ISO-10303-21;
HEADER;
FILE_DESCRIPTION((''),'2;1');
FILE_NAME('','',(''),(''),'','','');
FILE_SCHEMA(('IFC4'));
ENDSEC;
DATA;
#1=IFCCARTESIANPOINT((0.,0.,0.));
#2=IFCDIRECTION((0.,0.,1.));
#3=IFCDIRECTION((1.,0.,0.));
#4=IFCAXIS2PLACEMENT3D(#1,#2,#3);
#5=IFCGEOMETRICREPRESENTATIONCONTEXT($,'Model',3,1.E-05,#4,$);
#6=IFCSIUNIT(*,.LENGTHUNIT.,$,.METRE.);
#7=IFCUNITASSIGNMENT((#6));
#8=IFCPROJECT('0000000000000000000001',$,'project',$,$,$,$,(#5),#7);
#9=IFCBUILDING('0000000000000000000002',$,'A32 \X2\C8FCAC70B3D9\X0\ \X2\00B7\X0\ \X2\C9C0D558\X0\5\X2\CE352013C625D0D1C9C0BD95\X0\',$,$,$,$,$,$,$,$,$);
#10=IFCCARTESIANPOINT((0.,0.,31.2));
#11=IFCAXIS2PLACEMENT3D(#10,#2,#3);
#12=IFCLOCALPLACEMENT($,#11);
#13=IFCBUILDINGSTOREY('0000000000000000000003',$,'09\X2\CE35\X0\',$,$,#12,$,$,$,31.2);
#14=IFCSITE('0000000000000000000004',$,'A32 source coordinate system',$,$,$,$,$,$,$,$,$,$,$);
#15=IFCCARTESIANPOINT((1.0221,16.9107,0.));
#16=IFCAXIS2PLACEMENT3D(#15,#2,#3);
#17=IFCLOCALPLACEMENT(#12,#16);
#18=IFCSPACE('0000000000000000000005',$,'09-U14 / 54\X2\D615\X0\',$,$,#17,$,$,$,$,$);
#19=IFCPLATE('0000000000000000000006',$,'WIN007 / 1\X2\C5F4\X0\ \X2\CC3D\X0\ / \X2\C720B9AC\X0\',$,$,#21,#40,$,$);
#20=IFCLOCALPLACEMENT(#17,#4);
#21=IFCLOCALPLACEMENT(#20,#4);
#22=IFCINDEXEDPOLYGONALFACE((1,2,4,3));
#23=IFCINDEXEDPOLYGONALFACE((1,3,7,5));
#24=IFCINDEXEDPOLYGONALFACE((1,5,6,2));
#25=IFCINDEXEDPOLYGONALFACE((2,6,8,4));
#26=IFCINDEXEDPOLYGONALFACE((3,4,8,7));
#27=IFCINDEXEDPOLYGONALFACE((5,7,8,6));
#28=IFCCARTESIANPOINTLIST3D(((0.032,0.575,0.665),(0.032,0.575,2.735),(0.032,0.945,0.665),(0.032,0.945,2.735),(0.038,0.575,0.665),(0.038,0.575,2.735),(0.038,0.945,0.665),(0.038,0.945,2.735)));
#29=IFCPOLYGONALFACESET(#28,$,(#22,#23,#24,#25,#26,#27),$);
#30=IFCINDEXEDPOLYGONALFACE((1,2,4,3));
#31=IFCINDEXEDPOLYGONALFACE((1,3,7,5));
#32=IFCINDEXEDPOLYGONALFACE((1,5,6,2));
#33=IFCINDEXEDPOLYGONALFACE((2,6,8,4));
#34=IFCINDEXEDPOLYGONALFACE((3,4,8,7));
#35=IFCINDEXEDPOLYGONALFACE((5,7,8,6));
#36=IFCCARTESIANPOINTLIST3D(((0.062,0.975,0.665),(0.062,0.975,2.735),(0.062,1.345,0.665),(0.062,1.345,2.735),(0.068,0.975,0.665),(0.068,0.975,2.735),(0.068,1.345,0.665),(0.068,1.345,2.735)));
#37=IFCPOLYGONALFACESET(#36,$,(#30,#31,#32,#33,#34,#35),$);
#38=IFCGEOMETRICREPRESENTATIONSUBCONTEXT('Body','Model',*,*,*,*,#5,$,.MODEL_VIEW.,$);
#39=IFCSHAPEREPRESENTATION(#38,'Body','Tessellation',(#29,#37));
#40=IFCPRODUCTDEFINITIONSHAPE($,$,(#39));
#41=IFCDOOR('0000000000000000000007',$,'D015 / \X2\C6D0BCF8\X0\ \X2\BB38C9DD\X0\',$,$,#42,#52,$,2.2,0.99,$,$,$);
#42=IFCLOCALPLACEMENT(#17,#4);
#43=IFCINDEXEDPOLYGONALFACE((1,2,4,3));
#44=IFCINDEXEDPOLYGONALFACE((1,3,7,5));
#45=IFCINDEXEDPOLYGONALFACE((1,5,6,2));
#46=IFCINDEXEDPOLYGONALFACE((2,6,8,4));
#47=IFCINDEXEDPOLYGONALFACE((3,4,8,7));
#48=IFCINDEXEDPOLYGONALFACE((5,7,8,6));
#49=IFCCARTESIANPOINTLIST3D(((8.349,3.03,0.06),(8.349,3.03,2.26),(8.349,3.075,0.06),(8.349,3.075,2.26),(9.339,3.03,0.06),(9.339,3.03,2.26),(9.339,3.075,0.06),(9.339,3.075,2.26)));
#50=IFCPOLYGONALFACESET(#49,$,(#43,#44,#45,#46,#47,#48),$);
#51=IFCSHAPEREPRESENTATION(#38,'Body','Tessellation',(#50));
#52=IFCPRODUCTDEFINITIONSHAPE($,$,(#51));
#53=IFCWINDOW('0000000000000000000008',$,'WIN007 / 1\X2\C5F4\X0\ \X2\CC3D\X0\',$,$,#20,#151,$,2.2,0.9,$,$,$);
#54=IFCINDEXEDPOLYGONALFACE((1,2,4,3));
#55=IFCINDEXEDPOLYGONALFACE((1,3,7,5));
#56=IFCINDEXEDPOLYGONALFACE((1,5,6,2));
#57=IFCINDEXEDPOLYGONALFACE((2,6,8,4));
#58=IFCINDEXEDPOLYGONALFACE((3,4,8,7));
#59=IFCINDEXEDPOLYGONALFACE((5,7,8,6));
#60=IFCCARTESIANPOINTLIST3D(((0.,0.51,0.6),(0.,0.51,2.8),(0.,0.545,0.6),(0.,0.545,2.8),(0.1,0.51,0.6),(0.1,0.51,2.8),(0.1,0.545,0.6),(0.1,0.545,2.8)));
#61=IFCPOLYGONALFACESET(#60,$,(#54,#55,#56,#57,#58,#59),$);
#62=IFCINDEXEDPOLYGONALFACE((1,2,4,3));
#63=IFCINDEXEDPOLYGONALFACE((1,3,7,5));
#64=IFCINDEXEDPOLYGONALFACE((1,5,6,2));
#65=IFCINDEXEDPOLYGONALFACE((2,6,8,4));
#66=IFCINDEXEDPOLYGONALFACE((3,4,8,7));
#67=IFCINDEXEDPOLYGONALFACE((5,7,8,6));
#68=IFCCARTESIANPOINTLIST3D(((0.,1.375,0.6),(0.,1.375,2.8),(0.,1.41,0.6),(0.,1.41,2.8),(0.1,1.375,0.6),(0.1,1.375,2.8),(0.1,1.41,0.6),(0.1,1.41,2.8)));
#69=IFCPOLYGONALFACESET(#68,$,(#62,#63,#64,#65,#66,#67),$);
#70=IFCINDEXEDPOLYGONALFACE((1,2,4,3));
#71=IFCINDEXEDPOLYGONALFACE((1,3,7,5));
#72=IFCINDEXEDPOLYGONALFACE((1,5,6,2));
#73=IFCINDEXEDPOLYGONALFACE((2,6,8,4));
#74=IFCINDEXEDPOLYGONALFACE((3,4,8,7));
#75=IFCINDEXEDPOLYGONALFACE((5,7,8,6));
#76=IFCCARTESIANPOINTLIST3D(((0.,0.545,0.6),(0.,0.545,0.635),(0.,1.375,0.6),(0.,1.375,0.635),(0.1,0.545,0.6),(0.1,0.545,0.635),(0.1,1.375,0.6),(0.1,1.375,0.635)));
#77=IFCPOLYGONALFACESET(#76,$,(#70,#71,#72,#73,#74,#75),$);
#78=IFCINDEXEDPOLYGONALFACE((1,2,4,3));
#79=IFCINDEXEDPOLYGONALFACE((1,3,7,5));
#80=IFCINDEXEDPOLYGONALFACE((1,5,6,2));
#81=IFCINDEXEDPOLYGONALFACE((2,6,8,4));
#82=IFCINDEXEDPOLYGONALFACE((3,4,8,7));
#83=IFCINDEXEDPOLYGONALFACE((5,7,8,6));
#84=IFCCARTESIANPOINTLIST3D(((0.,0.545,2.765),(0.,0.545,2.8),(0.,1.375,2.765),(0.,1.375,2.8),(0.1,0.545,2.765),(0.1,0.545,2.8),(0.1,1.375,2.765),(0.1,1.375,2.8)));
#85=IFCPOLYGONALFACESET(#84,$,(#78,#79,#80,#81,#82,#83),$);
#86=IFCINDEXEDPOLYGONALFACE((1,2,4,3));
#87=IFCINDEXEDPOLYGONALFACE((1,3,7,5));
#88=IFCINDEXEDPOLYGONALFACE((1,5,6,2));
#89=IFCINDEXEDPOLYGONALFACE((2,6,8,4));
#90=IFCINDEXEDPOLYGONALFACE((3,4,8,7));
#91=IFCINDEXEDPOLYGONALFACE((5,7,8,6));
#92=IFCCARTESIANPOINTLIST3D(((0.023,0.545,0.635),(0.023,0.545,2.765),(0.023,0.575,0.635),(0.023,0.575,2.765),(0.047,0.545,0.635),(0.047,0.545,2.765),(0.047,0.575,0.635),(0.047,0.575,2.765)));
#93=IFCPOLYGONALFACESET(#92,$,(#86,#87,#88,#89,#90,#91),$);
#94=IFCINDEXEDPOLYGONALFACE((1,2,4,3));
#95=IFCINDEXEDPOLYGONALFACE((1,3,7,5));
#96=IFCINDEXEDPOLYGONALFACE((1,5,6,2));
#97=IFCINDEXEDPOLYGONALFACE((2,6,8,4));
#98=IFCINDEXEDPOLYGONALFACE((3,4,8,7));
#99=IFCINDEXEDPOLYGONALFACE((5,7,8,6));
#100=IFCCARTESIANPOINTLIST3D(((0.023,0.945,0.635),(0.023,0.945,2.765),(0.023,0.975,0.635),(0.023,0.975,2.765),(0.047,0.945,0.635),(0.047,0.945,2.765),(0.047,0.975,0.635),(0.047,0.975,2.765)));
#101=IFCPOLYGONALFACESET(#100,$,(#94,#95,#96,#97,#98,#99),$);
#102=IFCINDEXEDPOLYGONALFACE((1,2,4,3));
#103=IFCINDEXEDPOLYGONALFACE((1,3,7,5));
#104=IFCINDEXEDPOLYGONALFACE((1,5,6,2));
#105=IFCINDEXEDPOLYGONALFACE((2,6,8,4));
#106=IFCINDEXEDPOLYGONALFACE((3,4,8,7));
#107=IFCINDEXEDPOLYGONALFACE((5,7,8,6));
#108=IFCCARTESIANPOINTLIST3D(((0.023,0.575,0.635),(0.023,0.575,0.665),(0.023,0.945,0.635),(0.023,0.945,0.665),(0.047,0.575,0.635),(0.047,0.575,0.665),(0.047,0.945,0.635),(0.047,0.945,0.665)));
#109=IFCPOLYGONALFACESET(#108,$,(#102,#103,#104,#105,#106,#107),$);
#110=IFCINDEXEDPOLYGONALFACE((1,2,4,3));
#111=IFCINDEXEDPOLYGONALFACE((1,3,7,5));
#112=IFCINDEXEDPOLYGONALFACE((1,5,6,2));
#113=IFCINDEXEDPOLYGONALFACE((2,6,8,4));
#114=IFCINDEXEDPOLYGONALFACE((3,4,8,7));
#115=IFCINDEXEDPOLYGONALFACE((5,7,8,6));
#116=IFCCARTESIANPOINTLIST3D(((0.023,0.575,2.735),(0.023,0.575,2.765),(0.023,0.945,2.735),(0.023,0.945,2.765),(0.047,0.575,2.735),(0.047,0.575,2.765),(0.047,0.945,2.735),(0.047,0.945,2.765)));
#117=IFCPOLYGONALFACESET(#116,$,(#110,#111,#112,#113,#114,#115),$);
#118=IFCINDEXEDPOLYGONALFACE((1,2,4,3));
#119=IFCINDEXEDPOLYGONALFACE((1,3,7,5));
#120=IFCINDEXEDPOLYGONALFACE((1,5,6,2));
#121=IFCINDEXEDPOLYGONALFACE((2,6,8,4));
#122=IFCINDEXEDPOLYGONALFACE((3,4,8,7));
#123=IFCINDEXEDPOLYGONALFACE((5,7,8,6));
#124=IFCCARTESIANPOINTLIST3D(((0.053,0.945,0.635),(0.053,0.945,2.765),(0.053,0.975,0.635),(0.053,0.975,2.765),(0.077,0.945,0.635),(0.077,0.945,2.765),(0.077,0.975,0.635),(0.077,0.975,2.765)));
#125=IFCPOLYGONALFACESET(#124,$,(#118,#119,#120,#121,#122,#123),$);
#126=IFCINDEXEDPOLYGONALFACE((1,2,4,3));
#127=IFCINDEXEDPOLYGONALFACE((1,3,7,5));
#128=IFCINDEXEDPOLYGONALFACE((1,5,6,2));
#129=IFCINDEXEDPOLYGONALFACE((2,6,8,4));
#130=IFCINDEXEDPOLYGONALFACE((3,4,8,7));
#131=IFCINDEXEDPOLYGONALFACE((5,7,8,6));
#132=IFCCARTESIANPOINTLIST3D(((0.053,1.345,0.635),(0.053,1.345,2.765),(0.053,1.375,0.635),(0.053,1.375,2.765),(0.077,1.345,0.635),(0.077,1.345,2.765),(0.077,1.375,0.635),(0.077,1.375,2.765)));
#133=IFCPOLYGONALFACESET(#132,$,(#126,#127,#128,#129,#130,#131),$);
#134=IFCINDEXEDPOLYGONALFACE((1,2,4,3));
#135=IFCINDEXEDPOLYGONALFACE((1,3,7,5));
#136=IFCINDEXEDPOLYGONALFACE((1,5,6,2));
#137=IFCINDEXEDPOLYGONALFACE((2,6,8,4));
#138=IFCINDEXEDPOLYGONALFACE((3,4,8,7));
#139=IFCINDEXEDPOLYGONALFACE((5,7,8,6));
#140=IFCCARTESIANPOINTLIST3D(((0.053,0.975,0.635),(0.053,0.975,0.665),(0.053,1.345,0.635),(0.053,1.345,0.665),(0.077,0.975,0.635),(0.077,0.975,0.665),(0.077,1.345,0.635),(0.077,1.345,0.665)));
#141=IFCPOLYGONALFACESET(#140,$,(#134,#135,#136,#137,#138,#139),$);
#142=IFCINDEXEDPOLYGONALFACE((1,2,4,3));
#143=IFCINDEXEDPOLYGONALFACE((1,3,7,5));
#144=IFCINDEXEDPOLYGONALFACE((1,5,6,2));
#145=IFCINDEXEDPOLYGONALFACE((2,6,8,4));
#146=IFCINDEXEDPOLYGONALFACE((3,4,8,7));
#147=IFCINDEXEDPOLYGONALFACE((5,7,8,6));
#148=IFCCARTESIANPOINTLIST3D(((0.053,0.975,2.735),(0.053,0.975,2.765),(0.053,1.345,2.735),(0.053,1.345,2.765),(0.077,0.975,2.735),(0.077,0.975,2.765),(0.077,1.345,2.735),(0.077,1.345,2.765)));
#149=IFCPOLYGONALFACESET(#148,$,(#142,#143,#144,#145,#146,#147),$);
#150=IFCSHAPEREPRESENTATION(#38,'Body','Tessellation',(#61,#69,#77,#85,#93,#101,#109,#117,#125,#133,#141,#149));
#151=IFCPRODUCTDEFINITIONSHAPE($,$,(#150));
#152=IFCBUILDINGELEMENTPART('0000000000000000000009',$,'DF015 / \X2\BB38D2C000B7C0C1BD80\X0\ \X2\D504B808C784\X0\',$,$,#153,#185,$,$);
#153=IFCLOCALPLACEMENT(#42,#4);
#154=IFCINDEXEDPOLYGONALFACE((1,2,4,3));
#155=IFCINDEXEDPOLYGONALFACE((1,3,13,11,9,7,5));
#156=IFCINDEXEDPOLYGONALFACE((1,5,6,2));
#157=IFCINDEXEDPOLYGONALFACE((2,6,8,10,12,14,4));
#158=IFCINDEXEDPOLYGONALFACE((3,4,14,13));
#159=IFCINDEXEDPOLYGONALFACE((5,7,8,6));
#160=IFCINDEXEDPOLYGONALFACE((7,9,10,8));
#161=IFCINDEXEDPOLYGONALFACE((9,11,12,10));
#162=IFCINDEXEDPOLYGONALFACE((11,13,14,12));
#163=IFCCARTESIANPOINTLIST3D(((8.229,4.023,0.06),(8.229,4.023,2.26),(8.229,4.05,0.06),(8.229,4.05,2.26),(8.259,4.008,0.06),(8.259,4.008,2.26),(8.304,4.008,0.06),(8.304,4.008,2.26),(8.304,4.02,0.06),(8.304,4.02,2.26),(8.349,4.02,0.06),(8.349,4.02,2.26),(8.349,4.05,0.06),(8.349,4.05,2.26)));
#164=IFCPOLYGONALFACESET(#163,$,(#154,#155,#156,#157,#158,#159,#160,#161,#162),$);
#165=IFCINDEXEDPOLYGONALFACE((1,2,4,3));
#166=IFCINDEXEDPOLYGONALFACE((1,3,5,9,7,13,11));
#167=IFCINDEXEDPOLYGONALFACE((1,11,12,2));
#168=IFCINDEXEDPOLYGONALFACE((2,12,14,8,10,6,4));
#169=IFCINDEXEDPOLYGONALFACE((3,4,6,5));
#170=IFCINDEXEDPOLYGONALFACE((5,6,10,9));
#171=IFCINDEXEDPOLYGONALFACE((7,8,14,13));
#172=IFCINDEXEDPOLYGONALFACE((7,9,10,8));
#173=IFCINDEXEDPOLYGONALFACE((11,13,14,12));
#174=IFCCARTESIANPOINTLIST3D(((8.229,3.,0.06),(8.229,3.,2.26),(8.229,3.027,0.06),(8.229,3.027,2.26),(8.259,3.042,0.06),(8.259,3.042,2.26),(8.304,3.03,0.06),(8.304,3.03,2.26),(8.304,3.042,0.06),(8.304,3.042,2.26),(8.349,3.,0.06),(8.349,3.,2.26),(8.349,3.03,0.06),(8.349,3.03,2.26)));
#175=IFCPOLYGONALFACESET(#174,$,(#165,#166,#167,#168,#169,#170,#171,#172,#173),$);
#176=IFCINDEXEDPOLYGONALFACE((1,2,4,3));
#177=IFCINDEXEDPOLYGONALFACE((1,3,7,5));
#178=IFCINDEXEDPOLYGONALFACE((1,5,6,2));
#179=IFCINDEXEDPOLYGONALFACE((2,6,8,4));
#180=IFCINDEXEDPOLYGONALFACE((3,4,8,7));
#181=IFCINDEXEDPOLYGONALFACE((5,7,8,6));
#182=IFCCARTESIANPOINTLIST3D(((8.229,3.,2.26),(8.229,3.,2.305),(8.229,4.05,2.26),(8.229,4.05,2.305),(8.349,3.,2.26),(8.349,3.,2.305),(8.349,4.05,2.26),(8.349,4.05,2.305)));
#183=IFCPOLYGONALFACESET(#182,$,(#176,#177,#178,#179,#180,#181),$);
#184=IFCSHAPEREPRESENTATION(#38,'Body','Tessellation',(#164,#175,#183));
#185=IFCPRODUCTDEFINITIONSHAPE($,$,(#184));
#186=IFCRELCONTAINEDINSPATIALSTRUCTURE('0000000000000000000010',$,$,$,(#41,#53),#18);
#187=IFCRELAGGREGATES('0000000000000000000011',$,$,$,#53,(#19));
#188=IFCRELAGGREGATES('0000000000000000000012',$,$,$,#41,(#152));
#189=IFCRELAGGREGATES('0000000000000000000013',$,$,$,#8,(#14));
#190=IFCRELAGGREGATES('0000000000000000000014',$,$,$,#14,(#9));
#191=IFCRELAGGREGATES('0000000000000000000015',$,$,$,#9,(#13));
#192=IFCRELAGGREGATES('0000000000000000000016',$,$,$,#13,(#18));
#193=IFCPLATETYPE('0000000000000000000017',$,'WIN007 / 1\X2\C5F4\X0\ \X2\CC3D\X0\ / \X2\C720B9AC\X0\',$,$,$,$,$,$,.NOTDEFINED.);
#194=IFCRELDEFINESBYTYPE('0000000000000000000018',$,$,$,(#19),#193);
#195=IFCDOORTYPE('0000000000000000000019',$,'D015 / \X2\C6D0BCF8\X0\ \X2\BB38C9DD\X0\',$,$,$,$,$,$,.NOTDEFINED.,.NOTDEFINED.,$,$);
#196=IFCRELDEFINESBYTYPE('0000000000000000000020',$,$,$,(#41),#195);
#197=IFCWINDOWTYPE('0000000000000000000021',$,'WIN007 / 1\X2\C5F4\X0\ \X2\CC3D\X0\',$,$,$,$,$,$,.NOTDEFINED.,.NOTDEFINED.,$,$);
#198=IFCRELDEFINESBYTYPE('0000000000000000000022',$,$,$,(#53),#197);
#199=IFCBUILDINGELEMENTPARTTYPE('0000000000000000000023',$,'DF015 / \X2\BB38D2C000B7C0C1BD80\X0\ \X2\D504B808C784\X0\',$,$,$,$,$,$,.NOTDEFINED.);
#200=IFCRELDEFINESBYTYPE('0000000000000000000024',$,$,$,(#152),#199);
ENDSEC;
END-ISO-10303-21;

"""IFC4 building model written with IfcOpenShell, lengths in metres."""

from ifc_helpers import new_model, si_unit, frame, origin, origin_with_axes, place, context, subcontext, project, spatial, polyline, outline, extrude, source, transform, mapped, type_object, type_shapes, element, aggregate, save


model = new_model("IFC4")

# Units and contexts
model_context = context("Model", 3, precision=1e-05, world=origin_with_axes())
body_context = subcontext(model_context, "Body", "Model", "MODEL_VIEW")
ifc_project = project(units=[si_unit("LENGTHUNIT", "METRE")], contexts=[model_context])

# Plate
plate_type_1 = type_object("IfcPlateType", Name="WIN007 / 1열 창 / 유리", PredefinedType="NOTDEFINED")
shared_shape_1 = source(origin(), body_context, "Body", "SweptSolid", [
    extrude(outline(polyline([(0.032, 0.575), (0.032, 0.945), (0.038, 0.945), (0.038, 0.575), (0.032, 0.575)])), frame((0.0, 0.0, 0.665)), (0.0, 0.0, 1.0), 2.07),
    extrude(outline(polyline([(0.062, 0.975), (0.062, 1.345), (0.068, 1.345), (0.068, 0.975), (0.062, 0.975)])), frame((0.0, 0.0, 0.665)), (0.0, 0.0, 1.0), 2.07),
])
type_shapes(plate_type_1, [shared_shape_1])
storey_placement = place(None, frame((0.0, 0.0, 31.2), z_axis=(0.0, 0.0, 1.0), x_axis=(1.0, 0.0, 0.0)))
space_1_placement = place(storey_placement, frame((1.0221, 16.9107, 0.0), z_axis=(0.0, 0.0, 1.0), x_axis=(1.0, 0.0, 0.0)))
window_1_placement = place(space_1_placement, origin_with_axes())
plate_1_placement = place(window_1_placement, origin_with_axes())
plate_1 = element("IfcPlate", 1, at=plate_1_placement, type_object=plate_type_1, Name="WIN007 / 1열 창 / 유리", context=body_context, shape_type="MappedRepresentation", body=[
    mapped(shared_shape_1, transform((0.0, 0.0, 0.0), scale=1.0)),
])

# Site, building, storey, space
site = spatial("IfcSite", under=ifc_project, Name="A32 source coordinate system")
building = spatial("IfcBuilding", under=site, Name="A32 주거동 · 지하5층–옥탑지붕")
storey = spatial("IfcBuildingStorey", under=building, at=storey_placement, Name="09층", Elevation=31.2)
space_1 = spatial("IfcSpace", under=storey, at=space_1_placement, Name="09-U14 / 54형")

# Door
door_type_1 = type_object("IfcDoorType", Name="D015 / 원본 문짝", OperationType="NOTDEFINED", PredefinedType="NOTDEFINED")
shared_shape_2 = source(origin(), body_context, "Body", "SweptSolid", [
    extrude(outline(polyline([(9.339, 3.075), (9.339, 3.03), (8.349, 3.03), (8.349, 3.075), (9.339, 3.075)])), frame((0.0, 0.0, 0.06)), (0.0, 0.0, 1.0), 2.2),
])
type_shapes(door_type_1, [shared_shape_2])
door_1_placement = place(space_1_placement, origin_with_axes())
door_1 = element("IfcDoor", 2, at=door_1_placement, inside=space_1, type_object=door_type_1, Name="D015 / 원본 문짝", OverallHeight=2.2, OverallWidth=0.99, context=body_context, shape_type="MappedRepresentation", body=[
    mapped(shared_shape_2, transform((0.0, 0.0, 0.0), scale=1.0)),
])

# Window
window_type_1 = type_object("IfcWindowType", Name="WIN007 / 1열 창", PartitioningType="NOTDEFINED", PredefinedType="NOTDEFINED")
shared_shape_3 = source(origin(), body_context, "Body", "SweptSolid", [
    extrude(outline(polyline([(0.0, 0.51), (0.0, 0.545), (0.1, 0.545), (0.1, 0.51), (0.0, 0.51)])), frame((0.0, 0.0, 0.6)), (0.0, 0.0, 1.0), 2.2),
    extrude(outline(polyline([(0.0, 1.375), (0.0, 1.41), (0.1, 1.41), (0.1, 1.375), (0.0, 1.375)])), frame((0.0, 0.0, 0.6)), (0.0, 0.0, 1.0), 2.2),
    extrude(outline(polyline([(0.0, 0.545), (0.0, 1.375), (0.1, 1.375), (0.1, 0.545), (0.0, 0.545)])), frame((0.0, 0.0, 0.6)), (0.0, 0.0, 1.0), 0.035),
    extrude(outline(polyline([(0.0, 0.545), (0.0, 1.375), (0.1, 1.375), (0.1, 0.545), (0.0, 0.545)])), frame((0.0, 0.0, 2.765)), (0.0, 0.0, 1.0), 0.035),
    extrude(outline(polyline([(0.023, 0.545), (0.023, 0.575), (0.047, 0.575), (0.047, 0.545), (0.023, 0.545)])), frame((0.0, 0.0, 0.635)), (0.0, 0.0, 1.0), 2.13),
    extrude(outline(polyline([(0.023, 0.945), (0.023, 0.975), (0.047, 0.975), (0.047, 0.945), (0.023, 0.945)])), frame((0.0, 0.0, 0.635)), (0.0, 0.0, 1.0), 2.13),
    extrude(outline(polyline([(0.023, 0.575), (0.023, 0.945), (0.047, 0.945), (0.047, 0.575), (0.023, 0.575)])), frame((0.0, 0.0, 0.635)), (0.0, 0.0, 1.0), 0.03),
    extrude(outline(polyline([(0.023, 0.575), (0.023, 0.945), (0.047, 0.945), (0.047, 0.575), (0.023, 0.575)])), frame((0.0, 0.0, 2.735)), (0.0, 0.0, 1.0), 0.03),
    extrude(outline(polyline([(0.053, 0.945), (0.053, 0.975), (0.077, 0.975), (0.077, 0.945), (0.053, 0.945)])), frame((0.0, 0.0, 0.635)), (0.0, 0.0, 1.0), 2.13),
    extrude(outline(polyline([(0.053, 1.345), (0.053, 1.375), (0.077, 1.375), (0.077, 1.345), (0.053, 1.345)])), frame((0.0, 0.0, 0.635)), (0.0, 0.0, 1.0), 2.13),
    extrude(outline(polyline([(0.053, 0.975), (0.053, 1.345), (0.077, 1.345), (0.077, 0.975), (0.053, 0.975)])), frame((0.0, 0.0, 0.635)), (0.0, 0.0, 1.0), 0.03),
    extrude(outline(polyline([(0.053, 0.975), (0.053, 1.345), (0.077, 1.345), (0.077, 0.975), (0.053, 0.975)])), frame((0.0, 0.0, 2.735)), (0.0, 0.0, 1.0), 0.03),
])
type_shapes(window_type_1, [shared_shape_3])
window_1 = element("IfcWindow", 3, at=window_1_placement, inside=space_1, type_object=window_type_1, Name="WIN007 / 1열 창", OverallHeight=2.2, OverallWidth=0.9, context=body_context, shape_type="MappedRepresentation", body=[
    mapped(shared_shape_3, transform((0.0, 0.0, 0.0), scale=1.0)),
])
aggregate(window_1, [plate_1])

# Building element part
building_element_part_type_1 = type_object("IfcBuildingElementPartType", Name="DF015 / 문틀·상부 프레임", PredefinedType="NOTDEFINED")
shared_shape_4 = source(origin(), body_context, "Body", "SweptSolid", [
    extrude(outline(polyline([(8.349, 4.02), (8.304, 4.02), (8.304, 4.008), (8.259, 4.008), (8.229, 4.023), (8.229, 4.05), (8.349, 4.05), (8.349, 4.02)])), frame((0.0, 0.0, 0.06)), (0.0, 0.0, 1.0), 2.2),
    extrude(outline(polyline([(8.229, 3.0), (8.229, 3.027), (8.259, 3.042), (8.304, 3.042), (8.304, 3.03), (8.349, 3.03), (8.349, 3.0), (8.229, 3.0)])), frame((0.0, 0.0, 0.06)), (0.0, 0.0, 1.0), 2.2),
    extrude(outline(polyline([(8.229, 3.0), (8.229, 4.05), (8.349, 4.05), (8.349, 3.0), (8.229, 3.0)])), frame((0.0, 0.0, 2.26)), (0.0, 0.0, 1.0), 0.045),
])
type_shapes(building_element_part_type_1, [shared_shape_4])
building_element_part_1_placement = place(door_1_placement, origin_with_axes())
building_element_part_1 = element("IfcBuildingElementPart", 4, at=building_element_part_1_placement, type_object=building_element_part_type_1, Name="DF015 / 문틀·상부 프레임", context=body_context, shape_type="MappedRepresentation", body=[
    mapped(shared_shape_4, transform((0.0, 0.0, 0.0), scale=1.0)),
])
aggregate(door_1, [building_element_part_1])

save(model, "model.ifc")
